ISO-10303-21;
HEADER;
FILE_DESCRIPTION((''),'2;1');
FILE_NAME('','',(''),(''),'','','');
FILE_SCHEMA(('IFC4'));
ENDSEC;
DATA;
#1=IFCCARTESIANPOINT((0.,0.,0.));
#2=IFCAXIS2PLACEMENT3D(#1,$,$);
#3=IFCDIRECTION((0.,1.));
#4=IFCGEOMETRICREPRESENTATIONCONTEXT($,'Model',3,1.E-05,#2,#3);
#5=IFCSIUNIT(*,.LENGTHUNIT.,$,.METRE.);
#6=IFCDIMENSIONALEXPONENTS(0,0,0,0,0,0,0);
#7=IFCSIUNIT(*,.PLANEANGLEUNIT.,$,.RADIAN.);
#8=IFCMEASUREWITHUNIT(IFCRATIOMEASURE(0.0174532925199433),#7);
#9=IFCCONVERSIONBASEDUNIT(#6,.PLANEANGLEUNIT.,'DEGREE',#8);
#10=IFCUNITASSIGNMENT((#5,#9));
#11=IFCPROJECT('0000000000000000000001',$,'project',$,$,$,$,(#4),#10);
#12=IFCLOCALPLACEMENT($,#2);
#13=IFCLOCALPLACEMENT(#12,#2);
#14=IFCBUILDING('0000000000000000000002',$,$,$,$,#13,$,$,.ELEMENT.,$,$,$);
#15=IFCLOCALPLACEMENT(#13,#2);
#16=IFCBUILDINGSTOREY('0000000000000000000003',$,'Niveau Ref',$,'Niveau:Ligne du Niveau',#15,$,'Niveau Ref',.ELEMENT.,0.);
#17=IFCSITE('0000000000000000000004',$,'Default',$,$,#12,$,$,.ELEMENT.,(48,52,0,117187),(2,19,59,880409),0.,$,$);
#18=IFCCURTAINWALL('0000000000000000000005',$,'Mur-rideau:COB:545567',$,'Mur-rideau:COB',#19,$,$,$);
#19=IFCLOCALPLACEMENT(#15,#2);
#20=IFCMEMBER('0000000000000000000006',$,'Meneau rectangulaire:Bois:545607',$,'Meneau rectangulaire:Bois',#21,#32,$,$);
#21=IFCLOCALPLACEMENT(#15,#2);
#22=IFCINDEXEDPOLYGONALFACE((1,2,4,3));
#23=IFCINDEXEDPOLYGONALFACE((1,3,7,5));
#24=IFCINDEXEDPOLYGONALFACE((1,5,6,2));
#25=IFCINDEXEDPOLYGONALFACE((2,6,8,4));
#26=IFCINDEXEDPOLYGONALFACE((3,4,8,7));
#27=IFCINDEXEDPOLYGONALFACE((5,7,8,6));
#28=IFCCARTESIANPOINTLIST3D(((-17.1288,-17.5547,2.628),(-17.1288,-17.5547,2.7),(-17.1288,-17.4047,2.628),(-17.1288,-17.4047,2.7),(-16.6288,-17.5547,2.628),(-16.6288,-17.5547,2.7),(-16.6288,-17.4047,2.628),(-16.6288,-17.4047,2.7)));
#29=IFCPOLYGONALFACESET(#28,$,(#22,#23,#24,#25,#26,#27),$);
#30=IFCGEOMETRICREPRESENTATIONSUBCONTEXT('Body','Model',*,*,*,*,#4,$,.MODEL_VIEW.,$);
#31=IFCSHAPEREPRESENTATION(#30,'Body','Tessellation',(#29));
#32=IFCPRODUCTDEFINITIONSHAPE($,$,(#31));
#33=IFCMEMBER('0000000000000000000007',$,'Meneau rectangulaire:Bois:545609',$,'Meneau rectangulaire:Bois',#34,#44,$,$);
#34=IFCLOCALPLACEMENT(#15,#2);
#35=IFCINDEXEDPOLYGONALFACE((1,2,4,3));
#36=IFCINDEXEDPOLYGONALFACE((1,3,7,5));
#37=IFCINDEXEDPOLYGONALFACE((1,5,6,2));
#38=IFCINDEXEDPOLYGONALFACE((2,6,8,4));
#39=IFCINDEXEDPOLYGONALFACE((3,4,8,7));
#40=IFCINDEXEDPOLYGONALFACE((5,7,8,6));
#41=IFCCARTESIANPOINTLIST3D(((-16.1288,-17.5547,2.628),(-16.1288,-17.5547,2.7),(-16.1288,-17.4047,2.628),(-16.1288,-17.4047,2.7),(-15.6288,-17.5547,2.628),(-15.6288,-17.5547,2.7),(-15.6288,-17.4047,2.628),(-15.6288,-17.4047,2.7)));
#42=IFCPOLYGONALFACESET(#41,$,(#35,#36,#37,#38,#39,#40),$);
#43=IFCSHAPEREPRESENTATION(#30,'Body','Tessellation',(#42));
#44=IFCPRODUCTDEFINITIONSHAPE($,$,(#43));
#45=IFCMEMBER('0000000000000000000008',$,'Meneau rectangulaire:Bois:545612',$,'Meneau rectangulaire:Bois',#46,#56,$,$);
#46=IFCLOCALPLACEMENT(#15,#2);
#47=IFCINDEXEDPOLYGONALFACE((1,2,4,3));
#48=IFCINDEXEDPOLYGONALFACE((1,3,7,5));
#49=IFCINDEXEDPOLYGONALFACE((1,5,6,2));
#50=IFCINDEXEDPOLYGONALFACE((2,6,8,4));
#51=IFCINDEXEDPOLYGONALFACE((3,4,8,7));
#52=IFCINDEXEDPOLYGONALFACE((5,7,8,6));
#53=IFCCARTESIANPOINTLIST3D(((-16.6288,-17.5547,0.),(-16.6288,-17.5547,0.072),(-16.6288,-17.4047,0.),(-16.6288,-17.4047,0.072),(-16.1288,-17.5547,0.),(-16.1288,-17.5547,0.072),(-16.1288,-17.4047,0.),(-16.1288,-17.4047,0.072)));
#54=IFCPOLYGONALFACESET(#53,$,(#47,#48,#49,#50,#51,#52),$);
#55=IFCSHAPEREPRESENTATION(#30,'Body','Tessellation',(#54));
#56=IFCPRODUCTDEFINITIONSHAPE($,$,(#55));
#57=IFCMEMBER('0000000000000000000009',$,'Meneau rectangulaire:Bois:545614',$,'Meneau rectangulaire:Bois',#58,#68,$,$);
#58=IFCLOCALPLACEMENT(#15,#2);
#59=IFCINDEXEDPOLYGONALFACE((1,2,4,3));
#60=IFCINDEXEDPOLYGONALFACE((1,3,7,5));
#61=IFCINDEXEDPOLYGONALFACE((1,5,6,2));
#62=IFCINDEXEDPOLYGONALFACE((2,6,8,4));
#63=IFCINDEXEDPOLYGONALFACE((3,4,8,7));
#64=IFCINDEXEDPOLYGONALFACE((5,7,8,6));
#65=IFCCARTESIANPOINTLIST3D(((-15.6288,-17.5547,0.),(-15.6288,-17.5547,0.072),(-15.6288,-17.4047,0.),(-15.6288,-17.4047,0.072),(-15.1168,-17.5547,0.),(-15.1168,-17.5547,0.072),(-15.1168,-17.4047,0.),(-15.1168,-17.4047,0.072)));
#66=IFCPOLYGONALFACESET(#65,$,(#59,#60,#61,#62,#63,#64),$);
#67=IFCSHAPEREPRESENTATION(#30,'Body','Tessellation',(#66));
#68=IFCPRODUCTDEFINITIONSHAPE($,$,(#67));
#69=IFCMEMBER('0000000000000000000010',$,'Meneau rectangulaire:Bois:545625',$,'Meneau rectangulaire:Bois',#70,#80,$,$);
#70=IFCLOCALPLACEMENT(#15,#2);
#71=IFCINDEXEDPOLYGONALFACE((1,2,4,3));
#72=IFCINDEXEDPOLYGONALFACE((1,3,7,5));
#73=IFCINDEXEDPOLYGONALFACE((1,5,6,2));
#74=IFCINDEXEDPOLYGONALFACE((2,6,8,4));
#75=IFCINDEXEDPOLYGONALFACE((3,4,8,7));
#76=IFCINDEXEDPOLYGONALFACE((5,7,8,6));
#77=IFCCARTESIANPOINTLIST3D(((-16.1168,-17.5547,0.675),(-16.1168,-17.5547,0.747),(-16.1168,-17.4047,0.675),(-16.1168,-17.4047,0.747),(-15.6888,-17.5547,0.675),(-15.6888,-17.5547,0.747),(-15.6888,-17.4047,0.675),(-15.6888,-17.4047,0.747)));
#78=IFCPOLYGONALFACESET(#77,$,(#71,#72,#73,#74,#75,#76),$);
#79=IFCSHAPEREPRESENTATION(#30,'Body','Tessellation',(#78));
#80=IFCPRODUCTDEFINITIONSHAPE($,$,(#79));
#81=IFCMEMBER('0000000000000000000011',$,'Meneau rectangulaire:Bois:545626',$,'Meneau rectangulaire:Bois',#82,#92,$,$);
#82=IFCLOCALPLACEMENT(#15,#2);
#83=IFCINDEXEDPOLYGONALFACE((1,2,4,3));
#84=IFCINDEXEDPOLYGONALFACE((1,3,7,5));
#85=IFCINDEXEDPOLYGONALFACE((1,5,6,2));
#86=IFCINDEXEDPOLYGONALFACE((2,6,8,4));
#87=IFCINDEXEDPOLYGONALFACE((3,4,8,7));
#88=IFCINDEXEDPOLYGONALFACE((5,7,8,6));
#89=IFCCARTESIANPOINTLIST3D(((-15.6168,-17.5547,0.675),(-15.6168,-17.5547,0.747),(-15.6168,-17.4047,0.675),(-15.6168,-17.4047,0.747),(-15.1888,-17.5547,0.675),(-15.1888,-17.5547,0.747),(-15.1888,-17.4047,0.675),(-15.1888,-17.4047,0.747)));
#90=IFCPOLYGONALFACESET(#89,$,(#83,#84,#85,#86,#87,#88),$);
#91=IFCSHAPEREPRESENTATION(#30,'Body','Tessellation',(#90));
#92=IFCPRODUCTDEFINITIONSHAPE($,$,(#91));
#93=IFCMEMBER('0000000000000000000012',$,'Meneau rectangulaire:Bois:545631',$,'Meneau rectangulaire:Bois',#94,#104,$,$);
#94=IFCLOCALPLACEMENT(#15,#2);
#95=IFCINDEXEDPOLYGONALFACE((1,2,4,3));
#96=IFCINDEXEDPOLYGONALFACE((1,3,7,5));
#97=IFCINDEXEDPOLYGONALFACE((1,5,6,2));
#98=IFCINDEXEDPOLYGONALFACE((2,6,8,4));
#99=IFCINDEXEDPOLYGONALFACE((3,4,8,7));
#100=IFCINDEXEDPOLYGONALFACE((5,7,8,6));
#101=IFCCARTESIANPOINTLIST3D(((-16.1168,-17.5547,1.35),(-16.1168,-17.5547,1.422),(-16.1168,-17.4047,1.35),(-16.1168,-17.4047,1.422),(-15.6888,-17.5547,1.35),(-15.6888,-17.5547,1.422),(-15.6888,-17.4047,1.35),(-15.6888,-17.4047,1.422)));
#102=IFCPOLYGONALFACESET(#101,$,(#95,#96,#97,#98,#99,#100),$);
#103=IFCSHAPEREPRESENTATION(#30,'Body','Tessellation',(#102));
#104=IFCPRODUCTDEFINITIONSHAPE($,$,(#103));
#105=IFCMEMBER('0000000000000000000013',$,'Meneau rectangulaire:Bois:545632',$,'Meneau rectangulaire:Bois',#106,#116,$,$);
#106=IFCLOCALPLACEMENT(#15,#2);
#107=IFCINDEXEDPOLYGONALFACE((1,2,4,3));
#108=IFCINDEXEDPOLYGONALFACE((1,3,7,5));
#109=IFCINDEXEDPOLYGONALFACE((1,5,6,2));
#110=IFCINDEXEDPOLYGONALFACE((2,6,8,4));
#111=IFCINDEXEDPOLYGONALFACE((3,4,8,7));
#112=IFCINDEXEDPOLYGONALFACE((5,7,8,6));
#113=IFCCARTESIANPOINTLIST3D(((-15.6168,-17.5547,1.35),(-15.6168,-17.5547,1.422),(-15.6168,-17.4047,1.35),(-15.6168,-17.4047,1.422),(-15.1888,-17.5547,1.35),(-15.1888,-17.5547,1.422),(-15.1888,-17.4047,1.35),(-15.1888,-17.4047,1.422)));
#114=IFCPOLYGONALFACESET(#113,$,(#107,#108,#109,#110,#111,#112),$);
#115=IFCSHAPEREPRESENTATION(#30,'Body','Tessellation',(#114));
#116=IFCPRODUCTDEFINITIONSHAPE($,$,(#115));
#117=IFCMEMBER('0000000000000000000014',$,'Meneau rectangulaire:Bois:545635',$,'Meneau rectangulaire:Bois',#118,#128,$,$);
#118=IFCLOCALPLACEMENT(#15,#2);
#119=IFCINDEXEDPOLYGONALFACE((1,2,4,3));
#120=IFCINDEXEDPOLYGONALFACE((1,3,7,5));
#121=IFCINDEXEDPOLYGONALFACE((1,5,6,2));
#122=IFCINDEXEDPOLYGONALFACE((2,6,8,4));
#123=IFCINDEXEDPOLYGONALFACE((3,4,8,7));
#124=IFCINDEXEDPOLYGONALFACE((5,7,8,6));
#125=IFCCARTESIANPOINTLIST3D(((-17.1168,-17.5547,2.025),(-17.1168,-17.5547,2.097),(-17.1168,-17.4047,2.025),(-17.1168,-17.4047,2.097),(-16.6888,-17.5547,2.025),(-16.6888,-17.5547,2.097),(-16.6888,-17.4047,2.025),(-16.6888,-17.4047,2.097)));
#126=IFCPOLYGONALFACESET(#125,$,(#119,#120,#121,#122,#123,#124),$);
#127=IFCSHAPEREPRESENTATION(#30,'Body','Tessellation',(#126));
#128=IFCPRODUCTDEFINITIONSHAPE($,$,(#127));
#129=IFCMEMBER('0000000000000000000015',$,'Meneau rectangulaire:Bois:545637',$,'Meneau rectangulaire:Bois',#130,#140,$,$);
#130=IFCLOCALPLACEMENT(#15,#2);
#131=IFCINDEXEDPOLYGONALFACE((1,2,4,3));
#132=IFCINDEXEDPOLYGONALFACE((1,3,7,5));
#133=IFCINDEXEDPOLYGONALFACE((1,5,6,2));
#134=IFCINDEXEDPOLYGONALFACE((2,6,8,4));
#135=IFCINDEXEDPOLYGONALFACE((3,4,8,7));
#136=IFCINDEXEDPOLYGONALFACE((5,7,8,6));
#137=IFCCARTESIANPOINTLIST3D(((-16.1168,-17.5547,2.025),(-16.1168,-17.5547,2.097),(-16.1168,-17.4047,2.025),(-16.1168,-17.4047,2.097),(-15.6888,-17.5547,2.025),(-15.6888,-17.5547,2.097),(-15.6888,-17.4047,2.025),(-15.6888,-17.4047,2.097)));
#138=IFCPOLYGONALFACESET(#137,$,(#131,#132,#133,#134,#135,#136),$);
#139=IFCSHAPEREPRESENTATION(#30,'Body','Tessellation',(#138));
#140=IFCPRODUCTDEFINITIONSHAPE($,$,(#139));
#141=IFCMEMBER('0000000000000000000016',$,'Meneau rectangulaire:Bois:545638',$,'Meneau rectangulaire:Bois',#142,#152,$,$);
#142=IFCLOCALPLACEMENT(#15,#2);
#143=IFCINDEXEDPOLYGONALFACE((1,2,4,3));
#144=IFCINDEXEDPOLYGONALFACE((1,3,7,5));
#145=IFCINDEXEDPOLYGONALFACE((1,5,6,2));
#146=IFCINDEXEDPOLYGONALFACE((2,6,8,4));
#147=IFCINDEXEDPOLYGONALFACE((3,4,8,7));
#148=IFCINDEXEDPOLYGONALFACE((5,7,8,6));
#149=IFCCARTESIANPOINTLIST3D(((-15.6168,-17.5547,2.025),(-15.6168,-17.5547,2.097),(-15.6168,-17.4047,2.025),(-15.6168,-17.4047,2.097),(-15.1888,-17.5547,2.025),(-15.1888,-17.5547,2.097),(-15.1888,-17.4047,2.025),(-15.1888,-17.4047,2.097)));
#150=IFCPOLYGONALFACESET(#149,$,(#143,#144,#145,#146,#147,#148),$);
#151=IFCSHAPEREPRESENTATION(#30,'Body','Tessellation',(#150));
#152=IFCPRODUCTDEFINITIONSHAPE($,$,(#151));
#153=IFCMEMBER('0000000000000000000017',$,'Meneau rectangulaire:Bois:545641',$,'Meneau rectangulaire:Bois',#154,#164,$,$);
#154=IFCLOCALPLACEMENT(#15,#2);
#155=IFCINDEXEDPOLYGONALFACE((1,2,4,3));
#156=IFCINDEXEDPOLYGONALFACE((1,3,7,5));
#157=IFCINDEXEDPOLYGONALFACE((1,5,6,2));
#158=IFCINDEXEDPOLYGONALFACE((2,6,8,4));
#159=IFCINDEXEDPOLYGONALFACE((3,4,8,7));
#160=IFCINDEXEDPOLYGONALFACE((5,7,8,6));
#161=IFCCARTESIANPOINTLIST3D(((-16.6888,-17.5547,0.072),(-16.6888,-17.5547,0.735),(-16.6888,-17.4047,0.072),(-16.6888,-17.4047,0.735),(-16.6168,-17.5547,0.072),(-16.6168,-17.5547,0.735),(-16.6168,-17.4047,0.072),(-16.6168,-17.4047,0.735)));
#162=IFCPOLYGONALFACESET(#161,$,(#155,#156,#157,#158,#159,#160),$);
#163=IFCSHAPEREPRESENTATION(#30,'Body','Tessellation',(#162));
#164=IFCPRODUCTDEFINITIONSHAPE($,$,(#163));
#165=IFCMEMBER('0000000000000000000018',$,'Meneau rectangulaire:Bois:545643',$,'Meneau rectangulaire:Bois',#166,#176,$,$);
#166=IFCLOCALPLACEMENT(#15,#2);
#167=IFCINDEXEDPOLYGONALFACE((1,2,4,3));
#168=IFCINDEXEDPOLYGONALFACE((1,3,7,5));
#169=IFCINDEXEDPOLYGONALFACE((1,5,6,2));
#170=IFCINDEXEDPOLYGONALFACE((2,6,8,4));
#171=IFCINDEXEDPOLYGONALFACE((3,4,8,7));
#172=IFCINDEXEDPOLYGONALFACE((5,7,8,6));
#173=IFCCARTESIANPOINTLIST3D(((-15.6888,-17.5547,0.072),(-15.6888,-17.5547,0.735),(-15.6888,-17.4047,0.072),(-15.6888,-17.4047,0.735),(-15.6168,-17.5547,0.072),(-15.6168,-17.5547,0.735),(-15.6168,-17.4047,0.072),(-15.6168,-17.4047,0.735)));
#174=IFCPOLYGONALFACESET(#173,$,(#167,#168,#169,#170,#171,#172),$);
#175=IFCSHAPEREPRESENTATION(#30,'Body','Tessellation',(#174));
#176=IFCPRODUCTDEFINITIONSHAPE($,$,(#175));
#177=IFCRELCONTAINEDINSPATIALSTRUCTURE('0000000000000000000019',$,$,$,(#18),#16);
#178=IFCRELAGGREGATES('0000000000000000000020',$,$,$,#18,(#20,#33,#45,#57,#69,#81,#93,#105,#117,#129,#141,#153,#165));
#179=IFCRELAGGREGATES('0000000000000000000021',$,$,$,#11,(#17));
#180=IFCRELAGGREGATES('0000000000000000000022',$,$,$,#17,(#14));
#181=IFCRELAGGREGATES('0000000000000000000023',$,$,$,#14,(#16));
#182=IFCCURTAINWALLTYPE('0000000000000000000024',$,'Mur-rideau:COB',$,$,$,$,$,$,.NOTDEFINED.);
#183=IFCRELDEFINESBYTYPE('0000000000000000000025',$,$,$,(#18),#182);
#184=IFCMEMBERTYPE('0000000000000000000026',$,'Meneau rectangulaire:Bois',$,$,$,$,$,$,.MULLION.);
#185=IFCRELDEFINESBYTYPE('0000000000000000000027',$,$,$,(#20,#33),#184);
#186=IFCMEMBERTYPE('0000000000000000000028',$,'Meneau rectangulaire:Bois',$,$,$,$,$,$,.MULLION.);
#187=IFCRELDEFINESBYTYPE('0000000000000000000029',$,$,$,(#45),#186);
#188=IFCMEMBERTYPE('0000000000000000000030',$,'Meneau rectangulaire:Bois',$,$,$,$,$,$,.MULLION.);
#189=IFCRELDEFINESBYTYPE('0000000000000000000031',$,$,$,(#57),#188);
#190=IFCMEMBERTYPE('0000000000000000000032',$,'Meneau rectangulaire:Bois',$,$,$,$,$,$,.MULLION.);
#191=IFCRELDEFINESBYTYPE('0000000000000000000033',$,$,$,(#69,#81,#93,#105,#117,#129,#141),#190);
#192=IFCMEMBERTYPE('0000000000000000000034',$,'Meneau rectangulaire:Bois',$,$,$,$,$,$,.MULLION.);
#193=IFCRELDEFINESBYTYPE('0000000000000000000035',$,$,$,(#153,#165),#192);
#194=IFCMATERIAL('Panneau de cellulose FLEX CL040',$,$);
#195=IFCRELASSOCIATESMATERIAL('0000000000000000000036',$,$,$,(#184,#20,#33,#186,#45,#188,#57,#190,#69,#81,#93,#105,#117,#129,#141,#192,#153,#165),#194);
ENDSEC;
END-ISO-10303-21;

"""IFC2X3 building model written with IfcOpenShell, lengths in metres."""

from ifc_helpers import new_model, entity, si_unit, converted_unit, direction, frame, origin, origin_2d_with_axis, place, context, subcontext, project, spatial, rectangle, extrude, source, transform, mapped, material, type_object, type_shapes, element, aggregate, save


model = new_model("IFC2X3")

# Units and contexts
model_context = context("Model", 3, precision=1e-05, world=origin(), true_north=direction((0.0, 1.0)))
body_context = subcontext(model_context, "Body", "Model", "MODEL_VIEW")
ifc_project = project(units=[si_unit("LENGTHUNIT", "METRE"), converted_unit("PLANEANGLEUNIT", "DEGREE", entity("IfcRatioMeasure", 0.0174532925199433), si_unit("PLANEANGLEUNIT", "RADIAN"), dimensions=[0, 0, 0, 0, 0, 0, 0])], contexts=[model_context])

# Site, building, storey
site_placement = place(None, origin())
site = spatial("IfcSite", under=ifc_project, at=site_placement, Name="Default", CompositionType="ELEMENT", RefLatitude=(48, 52, 0, 117187), RefLongitude=(2, 19, 59, 880409), RefElevation=0.0)
building_placement = place(site_placement, origin())
building = spatial("IfcBuilding", under=site, at=building_placement, CompositionType="ELEMENT")
storey_placement = place(building_placement, origin())
storey = spatial("IfcBuildingStorey", under=building, at=storey_placement, Name="Niveau Ref", ObjectType="Niveau:Ligne du Niveau", LongName="Niveau Ref", CompositionType="ELEMENT", Elevation=0.0)

# Curtain wall, members
curtain_wall_type_1 = type_object("IfcCurtainWallType", Name="Mur-rideau:COB", PredefinedType="NOTDEFINED")
curtain_wall_1_placement = place(storey_placement, origin())
curtain_wall_1 = element("IfcCurtainWall", 1, at=curtain_wall_1_placement, inside=storey, type_object=curtain_wall_type_1, Name="Mur-rideau:COB:545567", ObjectType="Mur-rideau:COB")
ifc_material_1 = material(Name="Panneau de cellulose FLEX CL040")
member_type_1 = type_object("IfcMemberType", Name="Meneau rectangulaire:Bois", PredefinedType="MULLION", material=ifc_material_1)
shared_shape_1 = source(origin(), body_context, "Body", "SweptSolid", [
    extrude(rectangle(XDim=0.15, YDim=0.072, at=origin_2d_with_axis()), frame((-0.036, 0.0, -0.5), z_axis=(0.0, 0.0, 1.0), x_axis=(0.0, -1.0, 0.0)), (0.0, 0.0, 1.0), 0.5),
])
type_shapes(member_type_1, [shared_shape_1])
member_1_placement = place(storey_placement, frame((-16.6288, -17.4797, 2.7), z_axis=(1.0, 0.0, 0.0), x_axis=(0.0, 0.0, 1.0)))
member_1 = element("IfcMember", 2, at=member_1_placement, type_object=member_type_1, material=ifc_material_1, Name="Meneau rectangulaire:Bois:545607", ObjectType="Meneau rectangulaire:Bois", context=body_context, shape_type="MappedRepresentation", body=[
    mapped(shared_shape_1, transform((0.0, 0.0, 0.0), scale=1.0)),
])
member_2_placement = place(storey_placement, frame((-15.6288, -17.4797, 2.7), z_axis=(1.0, 0.0, 0.0), x_axis=(0.0, 0.0, 1.0)))
member_2 = element("IfcMember", 3, at=member_2_placement, type_object=member_type_1, material=ifc_material_1, Name="Meneau rectangulaire:Bois:545609", ObjectType="Meneau rectangulaire:Bois", context=body_context, shape_type="MappedRepresentation", body=[
    mapped(shared_shape_1, transform((0.0, 0.0, 0.0), scale=1.0)),
])
member_type_2 = type_object("IfcMemberType", Name="Meneau rectangulaire:Bois", PredefinedType="MULLION", material=ifc_material_1)
shared_shape_2 = source(origin(), body_context, "Body", "SweptSolid", [
    extrude(rectangle(XDim=0.15, YDim=0.072, at=origin_2d_with_axis()), frame((-0.036, 0.0, -0.5), z_axis=(0.0, 0.0, 1.0), x_axis=(0.0, -1.0, 0.0)), (0.0, 0.0, 1.0), 0.5),
])
type_shapes(member_type_2, [shared_shape_2])
member_3_placement = place(storey_placement, frame((-16.6288, -17.4797, 0.0), z_axis=(-1.0, 0.0, 0.0), x_axis=(0.0, 0.0, -1.0)))
member_3 = element("IfcMember", 4, at=member_3_placement, type_object=member_type_2, material=ifc_material_1, Name="Meneau rectangulaire:Bois:545612", ObjectType="Meneau rectangulaire:Bois", context=body_context, shape_type="MappedRepresentation", body=[
    mapped(shared_shape_2, transform((0.0, 0.0, 0.0), scale=1.0)),
])
member_type_3 = type_object("IfcMemberType", Name="Meneau rectangulaire:Bois", PredefinedType="MULLION", material=ifc_material_1)
shared_shape_3 = source(origin(), body_context, "Body", "SweptSolid", [
    extrude(rectangle(XDim=0.15, YDim=0.072, at=origin_2d_with_axis()), frame((-0.036, 0.0, -0.512), z_axis=(0.0, 0.0, 1.0), x_axis=(0.0, -1.0, 0.0)), (0.0, 0.0, 1.0), 0.512),
])
type_shapes(member_type_3, [shared_shape_3])
member_4_placement = place(storey_placement, frame((-15.6288, -17.4797, 0.0), z_axis=(-1.0, 0.0, 0.0), x_axis=(0.0, 0.0, -1.0)))
member_4 = element("IfcMember", 5, at=member_4_placement, type_object=member_type_3, material=ifc_material_1, Name="Meneau rectangulaire:Bois:545614", ObjectType="Meneau rectangulaire:Bois", context=body_context, shape_type="MappedRepresentation", body=[
    mapped(shared_shape_3, transform((0.0, 0.0, 0.0), scale=1.0)),
])
member_type_4 = type_object("IfcMemberType", Name="Meneau rectangulaire:Bois", PredefinedType="MULLION", material=ifc_material_1)
shared_shape_4 = source(origin(), body_context, "Body", "SweptSolid", [
    extrude(rectangle(XDim=0.15, YDim=0.072, at=origin_2d_with_axis()), frame((-0.024, 0.0, -0.428), z_axis=(0.0, 0.0, 1.0), x_axis=(0.0, -1.0, 0.0)), (0.0, 0.0, 1.0), 0.428),
])
type_shapes(member_type_4, [shared_shape_4])
member_5_placement = place(storey_placement, frame((-15.6888, -17.4797, 0.735), z_axis=(1.0, 0.0, 0.0), x_axis=(0.0, 0.0, 1.0)))
member_5 = element("IfcMember", 6, at=member_5_placement, type_object=member_type_4, material=ifc_material_1, Name="Meneau rectangulaire:Bois:545625", ObjectType="Meneau rectangulaire:Bois", context=body_context, shape_type="MappedRepresentation", body=[
    mapped(shared_shape_4, transform((0.0, 0.0, 0.0), scale=1.0)),
])
member_6_placement = place(storey_placement, frame((-15.1888, -17.4797, 0.735), z_axis=(1.0, 0.0, 0.0), x_axis=(0.0, 0.0, 1.0)))
member_6 = element("IfcMember", 7, at=member_6_placement, type_object=member_type_4, material=ifc_material_1, Name="Meneau rectangulaire:Bois:545626", ObjectType="Meneau rectangulaire:Bois", context=body_context, shape_type="MappedRepresentation", body=[
    mapped(shared_shape_4, transform((0.0, 0.0, 0.0), scale=1.0)),
])
member_7_placement = place(storey_placement, frame((-15.6888, -17.4797, 1.41), z_axis=(1.0, 0.0, 0.0), x_axis=(0.0, 0.0, 1.0)))
member_7 = element("IfcMember", 8, at=member_7_placement, type_object=member_type_4, material=ifc_material_1, Name="Meneau rectangulaire:Bois:545631", ObjectType="Meneau rectangulaire:Bois", context=body_context, shape_type="MappedRepresentation", body=[
    mapped(shared_shape_4, transform((0.0, 0.0, 0.0), scale=1.0)),
])
member_8_placement = place(storey_placement, frame((-15.1888, -17.4797, 1.41), z_axis=(1.0, 0.0, 0.0), x_axis=(0.0, 0.0, 1.0)))
member_8 = element("IfcMember", 9, at=member_8_placement, type_object=member_type_4, material=ifc_material_1, Name="Meneau rectangulaire:Bois:545632", ObjectType="Meneau rectangulaire:Bois", context=body_context, shape_type="MappedRepresentation", body=[
    mapped(shared_shape_4, transform((0.0, 0.0, 0.0), scale=1.0)),
])
member_9_placement = place(storey_placement, frame((-16.6888, -17.4797, 2.085), z_axis=(1.0, 0.0, 0.0), x_axis=(0.0, 0.0, 1.0)))
member_9 = element("IfcMember", 10, at=member_9_placement, type_object=member_type_4, material=ifc_material_1, Name="Meneau rectangulaire:Bois:545635", ObjectType="Meneau rectangulaire:Bois", context=body_context, shape_type="MappedRepresentation", body=[
    mapped(shared_shape_4, transform((0.0, 0.0, 0.0), scale=1.0)),
])
member_10_placement = place(storey_placement, frame((-15.6888, -17.4797, 2.085), z_axis=(1.0, 0.0, 0.0), x_axis=(0.0, 0.0, 1.0)))
member_10 = element("IfcMember", 11, at=member_10_placement, type_object=member_type_4, material=ifc_material_1, Name="Meneau rectangulaire:Bois:545637", ObjectType="Meneau rectangulaire:Bois", context=body_context, shape_type="MappedRepresentation", body=[
    mapped(shared_shape_4, transform((0.0, 0.0, 0.0), scale=1.0)),
])
member_11_placement = place(storey_placement, frame((-15.1888, -17.4797, 2.085), z_axis=(1.0, 0.0, 0.0), x_axis=(0.0, 0.0, 1.0)))
member_11 = element("IfcMember", 12, at=member_11_placement, type_object=member_type_4, material=ifc_material_1, Name="Meneau rectangulaire:Bois:545638", ObjectType="Meneau rectangulaire:Bois", context=body_context, shape_type="MappedRepresentation", body=[
    mapped(shared_shape_4, transform((0.0, 0.0, 0.0), scale=1.0)),
])
member_type_5 = type_object("IfcMemberType", Name="Meneau rectangulaire:Bois", PredefinedType="MULLION", material=ifc_material_1)
shared_shape_5 = source(origin(), body_context, "Body", "SweptSolid", [
    extrude(rectangle(XDim=0.15, YDim=0.072, at=origin_2d_with_axis()), frame((-0.024, 0.0, -0.663), z_axis=(0.0, 0.0, 1.0), x_axis=(0.0, -1.0, 0.0)), (0.0, 0.0, 1.0), 0.663),
])
type_shapes(member_type_5, [shared_shape_5])
member_12_placement = place(storey_placement, frame((-16.6288, -17.4797, 0.072), z_axis=(0.0, 0.0, -1.0), x_axis=(1.0, 0.0, 0.0)))
member_12 = element("IfcMember", 13, at=member_12_placement, type_object=member_type_5, material=ifc_material_1, Name="Meneau rectangulaire:Bois:545641", ObjectType="Meneau rectangulaire:Bois", context=body_context, shape_type="MappedRepresentation", body=[
    mapped(shared_shape_5, transform((0.0, 0.0, 0.0), scale=1.0)),
])
member_13_placement = place(storey_placement, frame((-15.6288, -17.4797, 0.072), z_axis=(0.0, 0.0, -1.0), x_axis=(1.0, 0.0, 0.0)))
member_13 = element("IfcMember", 14, at=member_13_placement, type_object=member_type_5, material=ifc_material_1, Name="Meneau rectangulaire:Bois:545643", ObjectType="Meneau rectangulaire:Bois", context=body_context, shape_type="MappedRepresentation", body=[
    mapped(shared_shape_5, transform((0.0, 0.0, 0.0), scale=1.0)),
])
aggregate(curtain_wall_1, [member_1, member_2, member_3, member_4, member_5, member_6, member_7, member_8, member_9, member_10, member_11, member_12, member_13])

save(model, "model.ifc")
